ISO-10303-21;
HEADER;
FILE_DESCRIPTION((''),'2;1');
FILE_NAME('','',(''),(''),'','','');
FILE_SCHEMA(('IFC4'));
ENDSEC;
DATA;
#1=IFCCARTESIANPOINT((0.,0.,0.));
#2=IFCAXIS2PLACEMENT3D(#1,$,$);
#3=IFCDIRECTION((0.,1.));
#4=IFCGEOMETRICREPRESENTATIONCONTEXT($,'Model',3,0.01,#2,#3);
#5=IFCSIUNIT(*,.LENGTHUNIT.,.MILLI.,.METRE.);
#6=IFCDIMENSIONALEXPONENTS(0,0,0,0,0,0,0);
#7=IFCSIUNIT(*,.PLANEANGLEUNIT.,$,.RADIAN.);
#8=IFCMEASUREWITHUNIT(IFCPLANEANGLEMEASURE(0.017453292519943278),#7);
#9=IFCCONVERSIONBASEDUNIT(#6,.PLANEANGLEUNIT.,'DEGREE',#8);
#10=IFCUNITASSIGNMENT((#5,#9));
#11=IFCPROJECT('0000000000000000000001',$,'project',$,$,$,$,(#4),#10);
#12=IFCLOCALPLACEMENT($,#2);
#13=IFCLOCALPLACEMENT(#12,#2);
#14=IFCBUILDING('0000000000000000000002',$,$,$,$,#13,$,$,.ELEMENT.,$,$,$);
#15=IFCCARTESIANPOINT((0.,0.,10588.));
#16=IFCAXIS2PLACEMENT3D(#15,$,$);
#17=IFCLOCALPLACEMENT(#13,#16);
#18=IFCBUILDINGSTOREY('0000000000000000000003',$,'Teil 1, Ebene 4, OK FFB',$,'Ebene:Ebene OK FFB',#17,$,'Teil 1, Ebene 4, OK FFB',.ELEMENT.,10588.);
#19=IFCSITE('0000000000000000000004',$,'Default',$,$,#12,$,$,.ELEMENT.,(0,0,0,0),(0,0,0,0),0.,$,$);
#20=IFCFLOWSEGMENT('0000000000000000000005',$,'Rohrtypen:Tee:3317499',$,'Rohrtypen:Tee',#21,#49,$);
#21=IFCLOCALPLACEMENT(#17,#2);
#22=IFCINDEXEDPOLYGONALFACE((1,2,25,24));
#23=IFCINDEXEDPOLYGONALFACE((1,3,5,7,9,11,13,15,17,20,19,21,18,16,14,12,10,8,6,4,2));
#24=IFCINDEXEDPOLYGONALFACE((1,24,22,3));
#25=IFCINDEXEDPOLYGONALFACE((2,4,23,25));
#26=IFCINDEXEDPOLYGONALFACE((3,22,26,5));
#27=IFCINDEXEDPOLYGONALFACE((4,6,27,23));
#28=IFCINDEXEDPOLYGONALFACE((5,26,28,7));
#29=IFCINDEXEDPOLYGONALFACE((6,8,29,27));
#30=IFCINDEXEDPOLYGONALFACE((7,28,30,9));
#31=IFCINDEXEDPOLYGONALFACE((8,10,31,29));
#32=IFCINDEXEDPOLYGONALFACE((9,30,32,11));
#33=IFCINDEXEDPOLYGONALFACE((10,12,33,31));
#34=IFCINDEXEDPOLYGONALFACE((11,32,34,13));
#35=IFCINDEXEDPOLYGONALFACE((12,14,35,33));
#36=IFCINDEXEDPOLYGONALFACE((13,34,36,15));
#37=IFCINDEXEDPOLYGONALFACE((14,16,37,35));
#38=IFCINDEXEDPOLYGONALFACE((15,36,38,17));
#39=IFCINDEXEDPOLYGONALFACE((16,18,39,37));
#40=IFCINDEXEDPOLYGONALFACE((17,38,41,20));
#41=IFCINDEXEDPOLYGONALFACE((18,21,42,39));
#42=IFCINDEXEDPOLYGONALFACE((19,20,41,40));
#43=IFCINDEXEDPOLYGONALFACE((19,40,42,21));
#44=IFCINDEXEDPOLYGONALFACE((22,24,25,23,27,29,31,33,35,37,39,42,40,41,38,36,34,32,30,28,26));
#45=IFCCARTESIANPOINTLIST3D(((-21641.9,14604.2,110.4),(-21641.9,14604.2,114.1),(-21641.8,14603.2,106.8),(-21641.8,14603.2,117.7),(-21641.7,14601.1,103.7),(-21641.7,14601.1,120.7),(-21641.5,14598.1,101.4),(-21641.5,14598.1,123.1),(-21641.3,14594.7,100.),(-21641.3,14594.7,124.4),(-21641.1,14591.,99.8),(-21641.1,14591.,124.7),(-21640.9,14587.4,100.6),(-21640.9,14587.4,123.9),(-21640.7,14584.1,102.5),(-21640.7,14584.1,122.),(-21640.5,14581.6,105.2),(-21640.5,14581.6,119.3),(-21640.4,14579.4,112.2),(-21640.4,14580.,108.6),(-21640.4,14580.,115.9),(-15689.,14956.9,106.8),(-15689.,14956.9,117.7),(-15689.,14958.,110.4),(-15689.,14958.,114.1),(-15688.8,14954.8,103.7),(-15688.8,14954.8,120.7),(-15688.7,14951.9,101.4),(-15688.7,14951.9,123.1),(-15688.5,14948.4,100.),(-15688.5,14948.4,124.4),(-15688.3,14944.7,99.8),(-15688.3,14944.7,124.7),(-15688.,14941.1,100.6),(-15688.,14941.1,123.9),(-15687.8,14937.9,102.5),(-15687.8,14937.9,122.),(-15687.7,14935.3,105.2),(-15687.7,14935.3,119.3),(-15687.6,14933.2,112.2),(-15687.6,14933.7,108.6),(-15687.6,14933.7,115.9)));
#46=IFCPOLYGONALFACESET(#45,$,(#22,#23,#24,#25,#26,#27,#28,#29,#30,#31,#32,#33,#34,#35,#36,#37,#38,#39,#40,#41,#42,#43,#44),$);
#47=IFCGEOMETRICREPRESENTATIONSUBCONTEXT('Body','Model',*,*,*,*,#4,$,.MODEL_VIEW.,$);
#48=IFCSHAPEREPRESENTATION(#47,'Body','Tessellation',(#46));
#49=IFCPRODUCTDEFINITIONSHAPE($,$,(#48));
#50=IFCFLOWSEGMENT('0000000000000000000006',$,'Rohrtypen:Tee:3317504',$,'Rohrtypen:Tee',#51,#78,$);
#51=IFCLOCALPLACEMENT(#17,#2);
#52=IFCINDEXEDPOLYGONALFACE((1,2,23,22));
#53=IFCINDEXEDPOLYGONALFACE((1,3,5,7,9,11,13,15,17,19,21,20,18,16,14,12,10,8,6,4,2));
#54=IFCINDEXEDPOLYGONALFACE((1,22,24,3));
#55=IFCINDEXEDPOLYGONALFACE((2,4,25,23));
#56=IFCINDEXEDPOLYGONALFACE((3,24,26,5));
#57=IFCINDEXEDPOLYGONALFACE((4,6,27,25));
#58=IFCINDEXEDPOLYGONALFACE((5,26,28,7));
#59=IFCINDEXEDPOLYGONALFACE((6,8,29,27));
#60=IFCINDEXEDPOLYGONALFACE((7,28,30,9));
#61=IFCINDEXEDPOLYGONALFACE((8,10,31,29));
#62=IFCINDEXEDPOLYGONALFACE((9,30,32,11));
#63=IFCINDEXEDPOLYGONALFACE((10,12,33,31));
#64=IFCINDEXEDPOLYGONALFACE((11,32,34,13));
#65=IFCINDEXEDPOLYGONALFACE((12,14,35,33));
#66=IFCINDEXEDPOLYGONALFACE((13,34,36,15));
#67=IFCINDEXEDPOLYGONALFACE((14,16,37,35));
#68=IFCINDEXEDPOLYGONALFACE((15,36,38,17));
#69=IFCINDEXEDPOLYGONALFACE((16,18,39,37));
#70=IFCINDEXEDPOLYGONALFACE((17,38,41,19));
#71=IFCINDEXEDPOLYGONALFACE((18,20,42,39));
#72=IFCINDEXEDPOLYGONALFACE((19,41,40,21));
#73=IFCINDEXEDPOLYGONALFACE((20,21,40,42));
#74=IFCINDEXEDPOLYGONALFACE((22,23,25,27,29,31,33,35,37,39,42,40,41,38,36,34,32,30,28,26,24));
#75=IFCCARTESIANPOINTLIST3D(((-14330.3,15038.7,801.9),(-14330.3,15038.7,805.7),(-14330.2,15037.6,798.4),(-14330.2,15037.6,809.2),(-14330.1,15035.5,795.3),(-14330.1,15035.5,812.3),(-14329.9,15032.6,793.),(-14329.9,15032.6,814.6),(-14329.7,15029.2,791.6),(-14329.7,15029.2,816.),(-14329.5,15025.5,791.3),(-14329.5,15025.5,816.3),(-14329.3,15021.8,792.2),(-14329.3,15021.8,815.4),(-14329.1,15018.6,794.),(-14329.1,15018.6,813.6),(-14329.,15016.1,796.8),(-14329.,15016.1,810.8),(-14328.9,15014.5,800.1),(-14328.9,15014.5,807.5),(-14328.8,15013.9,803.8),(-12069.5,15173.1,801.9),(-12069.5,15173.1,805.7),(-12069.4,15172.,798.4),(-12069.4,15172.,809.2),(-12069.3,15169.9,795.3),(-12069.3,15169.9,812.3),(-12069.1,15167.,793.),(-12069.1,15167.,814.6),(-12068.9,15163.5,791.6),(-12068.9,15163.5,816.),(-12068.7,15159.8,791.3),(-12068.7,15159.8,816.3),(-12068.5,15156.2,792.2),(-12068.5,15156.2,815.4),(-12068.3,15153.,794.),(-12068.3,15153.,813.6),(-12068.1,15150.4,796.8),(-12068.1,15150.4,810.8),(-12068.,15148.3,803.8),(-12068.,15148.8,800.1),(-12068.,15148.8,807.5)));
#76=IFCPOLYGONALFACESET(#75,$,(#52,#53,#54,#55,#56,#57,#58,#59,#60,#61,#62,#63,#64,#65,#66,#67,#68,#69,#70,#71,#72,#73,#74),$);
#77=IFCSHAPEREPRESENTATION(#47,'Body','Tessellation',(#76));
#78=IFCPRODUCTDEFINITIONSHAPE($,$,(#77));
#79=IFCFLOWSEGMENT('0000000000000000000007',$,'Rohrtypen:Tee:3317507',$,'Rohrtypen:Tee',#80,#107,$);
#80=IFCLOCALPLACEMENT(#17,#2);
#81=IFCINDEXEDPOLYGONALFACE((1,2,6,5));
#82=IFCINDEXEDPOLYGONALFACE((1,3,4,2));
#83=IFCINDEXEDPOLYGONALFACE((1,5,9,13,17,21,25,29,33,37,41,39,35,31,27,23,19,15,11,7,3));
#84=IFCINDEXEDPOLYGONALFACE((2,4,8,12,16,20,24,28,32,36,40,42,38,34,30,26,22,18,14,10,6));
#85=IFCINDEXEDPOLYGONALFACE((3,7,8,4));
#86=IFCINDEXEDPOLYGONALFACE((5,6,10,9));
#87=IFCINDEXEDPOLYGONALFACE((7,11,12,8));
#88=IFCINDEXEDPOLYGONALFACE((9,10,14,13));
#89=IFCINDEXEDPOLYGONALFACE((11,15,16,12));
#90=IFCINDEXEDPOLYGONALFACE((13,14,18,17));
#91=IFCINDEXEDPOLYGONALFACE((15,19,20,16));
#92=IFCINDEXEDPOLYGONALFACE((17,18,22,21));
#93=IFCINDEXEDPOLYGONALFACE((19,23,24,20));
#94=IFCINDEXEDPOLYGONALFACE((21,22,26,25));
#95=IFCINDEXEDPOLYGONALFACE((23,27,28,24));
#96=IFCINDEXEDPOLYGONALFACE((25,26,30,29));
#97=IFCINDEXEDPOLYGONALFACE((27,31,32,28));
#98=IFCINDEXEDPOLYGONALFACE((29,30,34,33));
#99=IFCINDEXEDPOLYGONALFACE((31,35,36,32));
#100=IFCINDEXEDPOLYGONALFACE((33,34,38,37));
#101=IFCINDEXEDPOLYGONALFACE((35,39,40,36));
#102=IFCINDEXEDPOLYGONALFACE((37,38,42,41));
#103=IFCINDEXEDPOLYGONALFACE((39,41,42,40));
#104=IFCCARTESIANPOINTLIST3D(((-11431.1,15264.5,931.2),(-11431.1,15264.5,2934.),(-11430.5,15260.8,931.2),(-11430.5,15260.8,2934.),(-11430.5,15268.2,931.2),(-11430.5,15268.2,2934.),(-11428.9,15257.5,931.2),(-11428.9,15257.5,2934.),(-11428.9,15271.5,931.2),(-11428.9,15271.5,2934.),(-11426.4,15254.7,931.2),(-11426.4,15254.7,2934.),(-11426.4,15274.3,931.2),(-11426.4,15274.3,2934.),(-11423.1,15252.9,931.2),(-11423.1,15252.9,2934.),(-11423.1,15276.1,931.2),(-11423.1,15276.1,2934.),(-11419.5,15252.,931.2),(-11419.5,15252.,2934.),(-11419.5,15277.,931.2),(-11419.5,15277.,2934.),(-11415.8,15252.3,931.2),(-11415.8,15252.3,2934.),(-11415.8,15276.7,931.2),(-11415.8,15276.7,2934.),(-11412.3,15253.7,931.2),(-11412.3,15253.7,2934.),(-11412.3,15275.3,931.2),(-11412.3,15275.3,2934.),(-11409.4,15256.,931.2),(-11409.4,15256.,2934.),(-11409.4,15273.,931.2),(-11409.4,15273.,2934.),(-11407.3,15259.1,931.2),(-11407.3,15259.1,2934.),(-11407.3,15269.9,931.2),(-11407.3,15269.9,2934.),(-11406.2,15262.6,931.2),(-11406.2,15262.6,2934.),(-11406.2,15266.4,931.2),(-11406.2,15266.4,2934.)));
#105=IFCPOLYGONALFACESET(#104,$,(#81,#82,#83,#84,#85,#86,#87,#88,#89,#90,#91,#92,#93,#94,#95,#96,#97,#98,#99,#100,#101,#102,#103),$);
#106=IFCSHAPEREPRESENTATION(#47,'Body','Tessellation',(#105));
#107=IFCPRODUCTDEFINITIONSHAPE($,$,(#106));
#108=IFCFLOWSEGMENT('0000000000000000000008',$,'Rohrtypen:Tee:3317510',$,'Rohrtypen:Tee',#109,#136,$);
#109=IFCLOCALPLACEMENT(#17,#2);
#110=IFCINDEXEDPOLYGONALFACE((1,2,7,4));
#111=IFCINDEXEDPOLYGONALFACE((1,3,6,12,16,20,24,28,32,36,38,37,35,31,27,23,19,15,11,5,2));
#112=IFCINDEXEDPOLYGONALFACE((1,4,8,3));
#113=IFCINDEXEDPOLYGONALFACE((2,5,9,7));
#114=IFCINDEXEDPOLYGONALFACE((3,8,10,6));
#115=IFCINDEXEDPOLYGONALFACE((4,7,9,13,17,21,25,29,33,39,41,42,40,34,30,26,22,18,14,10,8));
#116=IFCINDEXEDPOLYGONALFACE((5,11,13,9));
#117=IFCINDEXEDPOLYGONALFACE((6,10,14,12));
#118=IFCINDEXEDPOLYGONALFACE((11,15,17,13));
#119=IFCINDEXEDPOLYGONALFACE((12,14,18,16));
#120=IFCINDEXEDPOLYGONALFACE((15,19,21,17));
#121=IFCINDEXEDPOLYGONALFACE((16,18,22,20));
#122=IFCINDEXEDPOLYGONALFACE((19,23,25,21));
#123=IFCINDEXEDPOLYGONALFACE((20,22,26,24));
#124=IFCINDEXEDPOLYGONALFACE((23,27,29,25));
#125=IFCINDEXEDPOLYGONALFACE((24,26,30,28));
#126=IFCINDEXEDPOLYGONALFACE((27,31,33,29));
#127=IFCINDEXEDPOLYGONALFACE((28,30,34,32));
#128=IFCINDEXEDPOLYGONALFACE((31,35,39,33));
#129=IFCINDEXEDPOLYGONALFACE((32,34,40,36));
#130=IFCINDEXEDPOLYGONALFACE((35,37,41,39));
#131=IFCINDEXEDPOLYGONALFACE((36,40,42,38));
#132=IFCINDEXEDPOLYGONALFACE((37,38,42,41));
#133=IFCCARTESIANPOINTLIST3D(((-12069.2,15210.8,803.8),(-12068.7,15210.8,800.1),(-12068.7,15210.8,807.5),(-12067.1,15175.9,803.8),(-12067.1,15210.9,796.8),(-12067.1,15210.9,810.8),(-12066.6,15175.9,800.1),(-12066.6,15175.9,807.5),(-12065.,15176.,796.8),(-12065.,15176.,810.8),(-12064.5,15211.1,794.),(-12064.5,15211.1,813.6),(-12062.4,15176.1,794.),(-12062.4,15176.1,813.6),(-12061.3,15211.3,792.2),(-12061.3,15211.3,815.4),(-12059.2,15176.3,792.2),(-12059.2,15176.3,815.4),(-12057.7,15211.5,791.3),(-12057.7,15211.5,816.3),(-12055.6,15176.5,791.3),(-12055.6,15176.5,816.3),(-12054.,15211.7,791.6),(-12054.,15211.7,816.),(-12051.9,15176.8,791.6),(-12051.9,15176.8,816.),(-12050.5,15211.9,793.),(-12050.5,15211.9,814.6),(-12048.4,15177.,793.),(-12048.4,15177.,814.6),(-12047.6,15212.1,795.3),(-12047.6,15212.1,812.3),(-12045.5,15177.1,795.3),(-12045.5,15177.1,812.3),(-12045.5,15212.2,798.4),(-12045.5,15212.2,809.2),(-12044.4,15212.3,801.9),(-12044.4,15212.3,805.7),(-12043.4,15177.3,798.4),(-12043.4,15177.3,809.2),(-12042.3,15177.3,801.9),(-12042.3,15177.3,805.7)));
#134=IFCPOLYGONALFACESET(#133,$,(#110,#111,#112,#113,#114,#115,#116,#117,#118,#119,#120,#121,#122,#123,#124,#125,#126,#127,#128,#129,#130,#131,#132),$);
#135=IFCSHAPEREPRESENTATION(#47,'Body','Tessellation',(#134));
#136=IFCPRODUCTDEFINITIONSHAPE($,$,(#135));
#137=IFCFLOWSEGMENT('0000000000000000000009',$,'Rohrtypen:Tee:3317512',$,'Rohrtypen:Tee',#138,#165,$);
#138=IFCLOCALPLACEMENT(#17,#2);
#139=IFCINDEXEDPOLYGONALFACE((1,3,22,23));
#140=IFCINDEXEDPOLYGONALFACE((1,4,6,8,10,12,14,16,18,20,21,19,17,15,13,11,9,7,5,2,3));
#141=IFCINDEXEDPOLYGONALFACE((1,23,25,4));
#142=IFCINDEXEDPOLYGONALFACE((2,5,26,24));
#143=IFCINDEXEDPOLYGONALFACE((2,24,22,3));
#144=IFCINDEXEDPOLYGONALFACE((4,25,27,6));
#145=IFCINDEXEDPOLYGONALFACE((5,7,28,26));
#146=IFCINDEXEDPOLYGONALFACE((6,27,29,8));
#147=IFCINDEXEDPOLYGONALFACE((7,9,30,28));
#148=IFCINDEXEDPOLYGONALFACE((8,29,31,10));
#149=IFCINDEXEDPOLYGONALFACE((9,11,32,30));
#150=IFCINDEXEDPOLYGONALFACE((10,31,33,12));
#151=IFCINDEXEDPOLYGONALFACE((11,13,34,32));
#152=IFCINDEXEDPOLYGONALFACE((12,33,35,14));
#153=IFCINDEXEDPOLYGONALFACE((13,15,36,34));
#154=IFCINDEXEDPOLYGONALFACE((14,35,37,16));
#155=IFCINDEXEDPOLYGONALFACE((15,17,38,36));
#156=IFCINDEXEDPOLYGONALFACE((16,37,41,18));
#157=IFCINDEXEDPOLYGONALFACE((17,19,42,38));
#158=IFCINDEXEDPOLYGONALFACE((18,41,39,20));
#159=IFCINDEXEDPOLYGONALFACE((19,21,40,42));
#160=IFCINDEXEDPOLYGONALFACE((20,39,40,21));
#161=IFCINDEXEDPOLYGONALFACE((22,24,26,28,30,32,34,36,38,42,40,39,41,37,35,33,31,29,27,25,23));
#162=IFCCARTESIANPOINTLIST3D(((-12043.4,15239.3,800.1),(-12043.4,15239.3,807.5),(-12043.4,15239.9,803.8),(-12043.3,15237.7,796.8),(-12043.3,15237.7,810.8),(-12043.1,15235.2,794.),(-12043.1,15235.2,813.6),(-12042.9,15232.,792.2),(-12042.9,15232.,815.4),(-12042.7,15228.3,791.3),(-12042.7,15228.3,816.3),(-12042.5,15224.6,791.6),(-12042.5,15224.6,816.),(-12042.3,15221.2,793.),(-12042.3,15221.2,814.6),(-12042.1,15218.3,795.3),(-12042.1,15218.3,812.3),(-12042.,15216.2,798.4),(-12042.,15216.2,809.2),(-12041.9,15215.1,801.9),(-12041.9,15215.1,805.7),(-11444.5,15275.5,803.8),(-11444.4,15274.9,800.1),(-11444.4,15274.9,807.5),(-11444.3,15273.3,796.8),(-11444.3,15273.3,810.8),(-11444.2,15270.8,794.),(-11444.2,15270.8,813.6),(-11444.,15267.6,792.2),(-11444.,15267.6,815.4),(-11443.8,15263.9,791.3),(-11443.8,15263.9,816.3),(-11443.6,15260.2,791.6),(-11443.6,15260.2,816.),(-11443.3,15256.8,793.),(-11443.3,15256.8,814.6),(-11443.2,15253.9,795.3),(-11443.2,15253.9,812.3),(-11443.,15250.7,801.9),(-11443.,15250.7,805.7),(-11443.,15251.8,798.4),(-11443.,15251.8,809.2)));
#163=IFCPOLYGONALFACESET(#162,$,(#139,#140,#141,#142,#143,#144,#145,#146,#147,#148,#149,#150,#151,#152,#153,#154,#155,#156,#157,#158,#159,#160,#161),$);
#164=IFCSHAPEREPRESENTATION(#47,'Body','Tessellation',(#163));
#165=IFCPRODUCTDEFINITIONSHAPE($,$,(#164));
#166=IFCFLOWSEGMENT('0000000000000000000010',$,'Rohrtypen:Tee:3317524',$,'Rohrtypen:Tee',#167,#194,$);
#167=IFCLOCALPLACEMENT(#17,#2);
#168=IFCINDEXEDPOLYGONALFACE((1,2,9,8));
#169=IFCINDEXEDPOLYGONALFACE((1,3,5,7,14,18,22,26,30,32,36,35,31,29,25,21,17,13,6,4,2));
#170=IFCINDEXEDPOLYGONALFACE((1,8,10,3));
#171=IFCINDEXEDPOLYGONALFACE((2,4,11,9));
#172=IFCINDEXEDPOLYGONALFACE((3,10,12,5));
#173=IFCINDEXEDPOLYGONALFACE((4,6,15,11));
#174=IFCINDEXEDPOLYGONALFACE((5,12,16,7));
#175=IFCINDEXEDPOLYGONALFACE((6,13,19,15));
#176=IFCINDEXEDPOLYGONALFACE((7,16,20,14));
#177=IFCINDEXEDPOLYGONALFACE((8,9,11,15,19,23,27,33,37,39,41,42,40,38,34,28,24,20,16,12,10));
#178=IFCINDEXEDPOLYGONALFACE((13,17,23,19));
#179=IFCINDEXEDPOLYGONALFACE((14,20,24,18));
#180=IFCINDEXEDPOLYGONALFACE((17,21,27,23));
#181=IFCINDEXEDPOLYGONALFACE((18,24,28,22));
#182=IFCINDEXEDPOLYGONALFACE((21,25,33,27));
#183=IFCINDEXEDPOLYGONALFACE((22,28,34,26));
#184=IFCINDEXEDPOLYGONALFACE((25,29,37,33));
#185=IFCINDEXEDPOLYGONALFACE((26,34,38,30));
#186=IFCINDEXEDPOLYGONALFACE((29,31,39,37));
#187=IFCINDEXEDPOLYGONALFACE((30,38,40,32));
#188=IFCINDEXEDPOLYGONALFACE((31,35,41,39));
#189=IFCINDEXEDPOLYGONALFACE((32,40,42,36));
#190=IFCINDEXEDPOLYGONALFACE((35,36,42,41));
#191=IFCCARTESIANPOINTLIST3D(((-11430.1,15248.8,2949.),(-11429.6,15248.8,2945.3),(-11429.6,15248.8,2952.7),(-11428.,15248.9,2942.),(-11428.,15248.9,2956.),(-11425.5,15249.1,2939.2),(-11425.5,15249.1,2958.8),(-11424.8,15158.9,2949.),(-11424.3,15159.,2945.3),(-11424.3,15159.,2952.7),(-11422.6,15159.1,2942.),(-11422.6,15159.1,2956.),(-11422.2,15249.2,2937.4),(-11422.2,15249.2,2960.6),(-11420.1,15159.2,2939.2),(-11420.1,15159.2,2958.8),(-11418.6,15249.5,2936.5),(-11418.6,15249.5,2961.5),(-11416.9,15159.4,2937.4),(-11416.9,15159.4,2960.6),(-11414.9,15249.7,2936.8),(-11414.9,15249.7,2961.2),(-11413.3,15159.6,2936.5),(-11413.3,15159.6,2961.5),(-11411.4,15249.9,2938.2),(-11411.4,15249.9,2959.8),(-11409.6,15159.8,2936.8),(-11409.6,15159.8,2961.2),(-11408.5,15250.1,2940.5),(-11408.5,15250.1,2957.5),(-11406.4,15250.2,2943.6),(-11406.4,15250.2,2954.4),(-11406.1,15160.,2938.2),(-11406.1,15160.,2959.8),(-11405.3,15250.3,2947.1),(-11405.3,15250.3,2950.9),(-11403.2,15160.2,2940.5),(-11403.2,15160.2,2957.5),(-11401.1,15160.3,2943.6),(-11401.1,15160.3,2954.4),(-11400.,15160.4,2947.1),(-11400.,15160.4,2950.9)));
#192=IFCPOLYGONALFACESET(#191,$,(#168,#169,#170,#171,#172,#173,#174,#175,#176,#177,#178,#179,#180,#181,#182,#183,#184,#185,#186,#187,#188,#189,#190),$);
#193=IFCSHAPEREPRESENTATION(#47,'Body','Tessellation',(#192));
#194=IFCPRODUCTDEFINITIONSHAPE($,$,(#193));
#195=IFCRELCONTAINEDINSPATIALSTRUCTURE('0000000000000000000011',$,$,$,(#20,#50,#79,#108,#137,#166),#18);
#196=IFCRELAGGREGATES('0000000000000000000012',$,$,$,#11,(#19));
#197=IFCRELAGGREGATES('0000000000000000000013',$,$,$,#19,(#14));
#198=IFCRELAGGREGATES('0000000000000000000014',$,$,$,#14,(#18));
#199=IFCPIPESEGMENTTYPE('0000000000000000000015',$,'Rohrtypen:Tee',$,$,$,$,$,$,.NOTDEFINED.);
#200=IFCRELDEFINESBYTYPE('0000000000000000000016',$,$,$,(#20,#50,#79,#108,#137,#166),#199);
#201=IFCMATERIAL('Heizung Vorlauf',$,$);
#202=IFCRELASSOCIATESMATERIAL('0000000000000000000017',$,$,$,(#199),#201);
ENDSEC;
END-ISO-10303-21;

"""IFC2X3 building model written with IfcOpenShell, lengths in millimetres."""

from ifc_helpers import new_model, entity, si_unit, converted_unit, direction, frame, frame_2d, origin, origin_2d_with_axis, place, context, subcontext, project, spatial, circle, extrude, material, type_object, element, save


model = new_model("IFC2X3")

# Units and contexts
model_context = context("Model", 3, precision=0.01, world=origin(), true_north=direction((0.0, 1.0)))
body_context = subcontext(model_context, "Body", "Model", "MODEL_VIEW")
ifc_project = project(units=[si_unit("LENGTHUNIT", "METRE", prefix="MILLI"), converted_unit("PLANEANGLEUNIT", "DEGREE", entity("IfcPlaneAngleMeasure", 0.017453292519943278), si_unit("PLANEANGLEUNIT", "RADIAN"), dimensions=[0, 0, 0, 0, 0, 0, 0])], contexts=[model_context])

# Site, building, storey
site_placement = place(None, origin())
site = spatial("IfcSite", under=ifc_project, at=site_placement, Name="Default", CompositionType="ELEMENT", RefLatitude=(0, 0, 0, 0), RefLongitude=(0, 0, 0, 0), RefElevation=0.0)
building_placement = place(site_placement, origin())
building = spatial("IfcBuilding", under=site, at=building_placement, CompositionType="ELEMENT")
storey_placement = place(building_placement, frame((0.0, 0.0, 10588.0)))
storey = spatial("IfcBuildingStorey", under=building, at=storey_placement, Name="Teil 1, Ebene 4, OK FFB", ObjectType="Ebene:Ebene OK FFB", LongName="Teil 1, Ebene 4, OK FFB", CompositionType="ELEMENT", Elevation=10588.0)

# Flow segments
ifc_material = material(Name="Heizung Vorlauf")
pipe_segment_type = type_object("IfcPipeSegmentType", Name="Rohrtypen:Tee", PredefinedType="NOTDEFINED", material=ifc_material)
flow_segment_1_placement = place(storey_placement, origin())
element("IfcFlowSegment", 1, at=flow_segment_1_placement, inside=storey, type_object=pipe_segment_type, Name="Rohrtypen:Tee:3317499", ObjectType="Rohrtypen:Tee", context=body_context, shape_type="SweptSolid", body=[
    extrude(circle(Radius=12.5, at=origin_2d_with_axis()), frame((-21641.1, 14591.9, 112.2), z_axis=(0.998239, 0.059319, 0.0), x_axis=(0.059319, -0.998239, 0.0)), (0.0, 0.0, 1.0), 5963.3),
])
flow_segment_2_placement = place(storey_placement, origin())
element("IfcFlowSegment", 2, at=flow_segment_2_placement, inside=storey, type_object=pipe_segment_type, Name="Rohrtypen:Tee:3317504", ObjectType="Rohrtypen:Tee", context=body_context, shape_type="SweptSolid", body=[
    extrude(circle(Radius=12.5, at=origin_2d_with_axis()), frame((-14329.6, 15026.4, 803.8), z_axis=(0.998239, 0.059319, 0.0), x_axis=(0.059319, -0.998239, 0.0)), (0.0, 0.0, 1.0), 2264.8),
])
flow_segment_3_placement = place(storey_placement, origin())
element("IfcFlowSegment", 3, at=flow_segment_3_placement, inside=storey, type_object=pipe_segment_type, Name="Rohrtypen:Tee:3317507", ObjectType="Rohrtypen:Tee", context=body_context, shape_type="SweptSolid", body=[
    extrude(circle(Radius=12.5, at=frame_2d((0.0, 0.0), x_axis=(1.0, 0.0))), frame((-11418.6, 15264.5, 931.2), z_axis=(0.0, 0.0, 1.0), x_axis=(-1.0, 0.0, 0.0)), (0.0, 0.0, 1.0), 2002.8),
])
flow_segment_4_placement = place(storey_placement, origin())
element("IfcFlowSegment", 4, at=flow_segment_4_placement, inside=storey, type_object=pipe_segment_type, Name="Rohrtypen:Tee:3317510", ObjectType="Rohrtypen:Tee", context=body_context, shape_type="SweptSolid", body=[
    extrude(circle(Radius=12.5, at=origin_2d_with_axis()), frame((-12054.7, 15176.6, 803.8), z_axis=(-0.059319, 0.998239, 0.0), x_axis=(-0.998239, -0.059319, 0.0)), (0.0, 0.0, 1.0), 35.0),
])
flow_segment_5_placement = place(storey_placement, origin())
element("IfcFlowSegment", 5, at=flow_segment_5_placement, inside=storey, type_object=pipe_segment_type, Name="Rohrtypen:Tee:3317512", ObjectType="Rohrtypen:Tee", context=body_context, shape_type="SweptSolid", body=[
    extrude(circle(Radius=12.5, at=frame_2d((0.0, 0.0), x_axis=(1.0, 0.0))), frame((-12042.7, 15227.4, 803.8), z_axis=(0.998239, 0.059319, 0.0), x_axis=(-0.059319, 0.998239, 0.0)), (0.0, 0.0, 1.0), 600.0),
])
flow_segment_6_placement = place(storey_placement, origin())
element("IfcFlowSegment", 6, at=flow_segment_6_placement, inside=storey, type_object=pipe_segment_type, Name="Rohrtypen:Tee:3317524", ObjectType="Rohrtypen:Tee", context=body_context, shape_type="SweptSolid", body=[
    extrude(circle(Radius=12.5, at=frame_2d((0.0, 0.0), x_axis=(1.0, 0.0))), frame((-11417.7, 15249.5, 2949.0), z_axis=(0.059319, -0.998239, 0.0), x_axis=(-0.998239, -0.059319, 0.0)), (0.0, 0.0, 1.0), 90.0),
])

save(model, "model.ifc")
